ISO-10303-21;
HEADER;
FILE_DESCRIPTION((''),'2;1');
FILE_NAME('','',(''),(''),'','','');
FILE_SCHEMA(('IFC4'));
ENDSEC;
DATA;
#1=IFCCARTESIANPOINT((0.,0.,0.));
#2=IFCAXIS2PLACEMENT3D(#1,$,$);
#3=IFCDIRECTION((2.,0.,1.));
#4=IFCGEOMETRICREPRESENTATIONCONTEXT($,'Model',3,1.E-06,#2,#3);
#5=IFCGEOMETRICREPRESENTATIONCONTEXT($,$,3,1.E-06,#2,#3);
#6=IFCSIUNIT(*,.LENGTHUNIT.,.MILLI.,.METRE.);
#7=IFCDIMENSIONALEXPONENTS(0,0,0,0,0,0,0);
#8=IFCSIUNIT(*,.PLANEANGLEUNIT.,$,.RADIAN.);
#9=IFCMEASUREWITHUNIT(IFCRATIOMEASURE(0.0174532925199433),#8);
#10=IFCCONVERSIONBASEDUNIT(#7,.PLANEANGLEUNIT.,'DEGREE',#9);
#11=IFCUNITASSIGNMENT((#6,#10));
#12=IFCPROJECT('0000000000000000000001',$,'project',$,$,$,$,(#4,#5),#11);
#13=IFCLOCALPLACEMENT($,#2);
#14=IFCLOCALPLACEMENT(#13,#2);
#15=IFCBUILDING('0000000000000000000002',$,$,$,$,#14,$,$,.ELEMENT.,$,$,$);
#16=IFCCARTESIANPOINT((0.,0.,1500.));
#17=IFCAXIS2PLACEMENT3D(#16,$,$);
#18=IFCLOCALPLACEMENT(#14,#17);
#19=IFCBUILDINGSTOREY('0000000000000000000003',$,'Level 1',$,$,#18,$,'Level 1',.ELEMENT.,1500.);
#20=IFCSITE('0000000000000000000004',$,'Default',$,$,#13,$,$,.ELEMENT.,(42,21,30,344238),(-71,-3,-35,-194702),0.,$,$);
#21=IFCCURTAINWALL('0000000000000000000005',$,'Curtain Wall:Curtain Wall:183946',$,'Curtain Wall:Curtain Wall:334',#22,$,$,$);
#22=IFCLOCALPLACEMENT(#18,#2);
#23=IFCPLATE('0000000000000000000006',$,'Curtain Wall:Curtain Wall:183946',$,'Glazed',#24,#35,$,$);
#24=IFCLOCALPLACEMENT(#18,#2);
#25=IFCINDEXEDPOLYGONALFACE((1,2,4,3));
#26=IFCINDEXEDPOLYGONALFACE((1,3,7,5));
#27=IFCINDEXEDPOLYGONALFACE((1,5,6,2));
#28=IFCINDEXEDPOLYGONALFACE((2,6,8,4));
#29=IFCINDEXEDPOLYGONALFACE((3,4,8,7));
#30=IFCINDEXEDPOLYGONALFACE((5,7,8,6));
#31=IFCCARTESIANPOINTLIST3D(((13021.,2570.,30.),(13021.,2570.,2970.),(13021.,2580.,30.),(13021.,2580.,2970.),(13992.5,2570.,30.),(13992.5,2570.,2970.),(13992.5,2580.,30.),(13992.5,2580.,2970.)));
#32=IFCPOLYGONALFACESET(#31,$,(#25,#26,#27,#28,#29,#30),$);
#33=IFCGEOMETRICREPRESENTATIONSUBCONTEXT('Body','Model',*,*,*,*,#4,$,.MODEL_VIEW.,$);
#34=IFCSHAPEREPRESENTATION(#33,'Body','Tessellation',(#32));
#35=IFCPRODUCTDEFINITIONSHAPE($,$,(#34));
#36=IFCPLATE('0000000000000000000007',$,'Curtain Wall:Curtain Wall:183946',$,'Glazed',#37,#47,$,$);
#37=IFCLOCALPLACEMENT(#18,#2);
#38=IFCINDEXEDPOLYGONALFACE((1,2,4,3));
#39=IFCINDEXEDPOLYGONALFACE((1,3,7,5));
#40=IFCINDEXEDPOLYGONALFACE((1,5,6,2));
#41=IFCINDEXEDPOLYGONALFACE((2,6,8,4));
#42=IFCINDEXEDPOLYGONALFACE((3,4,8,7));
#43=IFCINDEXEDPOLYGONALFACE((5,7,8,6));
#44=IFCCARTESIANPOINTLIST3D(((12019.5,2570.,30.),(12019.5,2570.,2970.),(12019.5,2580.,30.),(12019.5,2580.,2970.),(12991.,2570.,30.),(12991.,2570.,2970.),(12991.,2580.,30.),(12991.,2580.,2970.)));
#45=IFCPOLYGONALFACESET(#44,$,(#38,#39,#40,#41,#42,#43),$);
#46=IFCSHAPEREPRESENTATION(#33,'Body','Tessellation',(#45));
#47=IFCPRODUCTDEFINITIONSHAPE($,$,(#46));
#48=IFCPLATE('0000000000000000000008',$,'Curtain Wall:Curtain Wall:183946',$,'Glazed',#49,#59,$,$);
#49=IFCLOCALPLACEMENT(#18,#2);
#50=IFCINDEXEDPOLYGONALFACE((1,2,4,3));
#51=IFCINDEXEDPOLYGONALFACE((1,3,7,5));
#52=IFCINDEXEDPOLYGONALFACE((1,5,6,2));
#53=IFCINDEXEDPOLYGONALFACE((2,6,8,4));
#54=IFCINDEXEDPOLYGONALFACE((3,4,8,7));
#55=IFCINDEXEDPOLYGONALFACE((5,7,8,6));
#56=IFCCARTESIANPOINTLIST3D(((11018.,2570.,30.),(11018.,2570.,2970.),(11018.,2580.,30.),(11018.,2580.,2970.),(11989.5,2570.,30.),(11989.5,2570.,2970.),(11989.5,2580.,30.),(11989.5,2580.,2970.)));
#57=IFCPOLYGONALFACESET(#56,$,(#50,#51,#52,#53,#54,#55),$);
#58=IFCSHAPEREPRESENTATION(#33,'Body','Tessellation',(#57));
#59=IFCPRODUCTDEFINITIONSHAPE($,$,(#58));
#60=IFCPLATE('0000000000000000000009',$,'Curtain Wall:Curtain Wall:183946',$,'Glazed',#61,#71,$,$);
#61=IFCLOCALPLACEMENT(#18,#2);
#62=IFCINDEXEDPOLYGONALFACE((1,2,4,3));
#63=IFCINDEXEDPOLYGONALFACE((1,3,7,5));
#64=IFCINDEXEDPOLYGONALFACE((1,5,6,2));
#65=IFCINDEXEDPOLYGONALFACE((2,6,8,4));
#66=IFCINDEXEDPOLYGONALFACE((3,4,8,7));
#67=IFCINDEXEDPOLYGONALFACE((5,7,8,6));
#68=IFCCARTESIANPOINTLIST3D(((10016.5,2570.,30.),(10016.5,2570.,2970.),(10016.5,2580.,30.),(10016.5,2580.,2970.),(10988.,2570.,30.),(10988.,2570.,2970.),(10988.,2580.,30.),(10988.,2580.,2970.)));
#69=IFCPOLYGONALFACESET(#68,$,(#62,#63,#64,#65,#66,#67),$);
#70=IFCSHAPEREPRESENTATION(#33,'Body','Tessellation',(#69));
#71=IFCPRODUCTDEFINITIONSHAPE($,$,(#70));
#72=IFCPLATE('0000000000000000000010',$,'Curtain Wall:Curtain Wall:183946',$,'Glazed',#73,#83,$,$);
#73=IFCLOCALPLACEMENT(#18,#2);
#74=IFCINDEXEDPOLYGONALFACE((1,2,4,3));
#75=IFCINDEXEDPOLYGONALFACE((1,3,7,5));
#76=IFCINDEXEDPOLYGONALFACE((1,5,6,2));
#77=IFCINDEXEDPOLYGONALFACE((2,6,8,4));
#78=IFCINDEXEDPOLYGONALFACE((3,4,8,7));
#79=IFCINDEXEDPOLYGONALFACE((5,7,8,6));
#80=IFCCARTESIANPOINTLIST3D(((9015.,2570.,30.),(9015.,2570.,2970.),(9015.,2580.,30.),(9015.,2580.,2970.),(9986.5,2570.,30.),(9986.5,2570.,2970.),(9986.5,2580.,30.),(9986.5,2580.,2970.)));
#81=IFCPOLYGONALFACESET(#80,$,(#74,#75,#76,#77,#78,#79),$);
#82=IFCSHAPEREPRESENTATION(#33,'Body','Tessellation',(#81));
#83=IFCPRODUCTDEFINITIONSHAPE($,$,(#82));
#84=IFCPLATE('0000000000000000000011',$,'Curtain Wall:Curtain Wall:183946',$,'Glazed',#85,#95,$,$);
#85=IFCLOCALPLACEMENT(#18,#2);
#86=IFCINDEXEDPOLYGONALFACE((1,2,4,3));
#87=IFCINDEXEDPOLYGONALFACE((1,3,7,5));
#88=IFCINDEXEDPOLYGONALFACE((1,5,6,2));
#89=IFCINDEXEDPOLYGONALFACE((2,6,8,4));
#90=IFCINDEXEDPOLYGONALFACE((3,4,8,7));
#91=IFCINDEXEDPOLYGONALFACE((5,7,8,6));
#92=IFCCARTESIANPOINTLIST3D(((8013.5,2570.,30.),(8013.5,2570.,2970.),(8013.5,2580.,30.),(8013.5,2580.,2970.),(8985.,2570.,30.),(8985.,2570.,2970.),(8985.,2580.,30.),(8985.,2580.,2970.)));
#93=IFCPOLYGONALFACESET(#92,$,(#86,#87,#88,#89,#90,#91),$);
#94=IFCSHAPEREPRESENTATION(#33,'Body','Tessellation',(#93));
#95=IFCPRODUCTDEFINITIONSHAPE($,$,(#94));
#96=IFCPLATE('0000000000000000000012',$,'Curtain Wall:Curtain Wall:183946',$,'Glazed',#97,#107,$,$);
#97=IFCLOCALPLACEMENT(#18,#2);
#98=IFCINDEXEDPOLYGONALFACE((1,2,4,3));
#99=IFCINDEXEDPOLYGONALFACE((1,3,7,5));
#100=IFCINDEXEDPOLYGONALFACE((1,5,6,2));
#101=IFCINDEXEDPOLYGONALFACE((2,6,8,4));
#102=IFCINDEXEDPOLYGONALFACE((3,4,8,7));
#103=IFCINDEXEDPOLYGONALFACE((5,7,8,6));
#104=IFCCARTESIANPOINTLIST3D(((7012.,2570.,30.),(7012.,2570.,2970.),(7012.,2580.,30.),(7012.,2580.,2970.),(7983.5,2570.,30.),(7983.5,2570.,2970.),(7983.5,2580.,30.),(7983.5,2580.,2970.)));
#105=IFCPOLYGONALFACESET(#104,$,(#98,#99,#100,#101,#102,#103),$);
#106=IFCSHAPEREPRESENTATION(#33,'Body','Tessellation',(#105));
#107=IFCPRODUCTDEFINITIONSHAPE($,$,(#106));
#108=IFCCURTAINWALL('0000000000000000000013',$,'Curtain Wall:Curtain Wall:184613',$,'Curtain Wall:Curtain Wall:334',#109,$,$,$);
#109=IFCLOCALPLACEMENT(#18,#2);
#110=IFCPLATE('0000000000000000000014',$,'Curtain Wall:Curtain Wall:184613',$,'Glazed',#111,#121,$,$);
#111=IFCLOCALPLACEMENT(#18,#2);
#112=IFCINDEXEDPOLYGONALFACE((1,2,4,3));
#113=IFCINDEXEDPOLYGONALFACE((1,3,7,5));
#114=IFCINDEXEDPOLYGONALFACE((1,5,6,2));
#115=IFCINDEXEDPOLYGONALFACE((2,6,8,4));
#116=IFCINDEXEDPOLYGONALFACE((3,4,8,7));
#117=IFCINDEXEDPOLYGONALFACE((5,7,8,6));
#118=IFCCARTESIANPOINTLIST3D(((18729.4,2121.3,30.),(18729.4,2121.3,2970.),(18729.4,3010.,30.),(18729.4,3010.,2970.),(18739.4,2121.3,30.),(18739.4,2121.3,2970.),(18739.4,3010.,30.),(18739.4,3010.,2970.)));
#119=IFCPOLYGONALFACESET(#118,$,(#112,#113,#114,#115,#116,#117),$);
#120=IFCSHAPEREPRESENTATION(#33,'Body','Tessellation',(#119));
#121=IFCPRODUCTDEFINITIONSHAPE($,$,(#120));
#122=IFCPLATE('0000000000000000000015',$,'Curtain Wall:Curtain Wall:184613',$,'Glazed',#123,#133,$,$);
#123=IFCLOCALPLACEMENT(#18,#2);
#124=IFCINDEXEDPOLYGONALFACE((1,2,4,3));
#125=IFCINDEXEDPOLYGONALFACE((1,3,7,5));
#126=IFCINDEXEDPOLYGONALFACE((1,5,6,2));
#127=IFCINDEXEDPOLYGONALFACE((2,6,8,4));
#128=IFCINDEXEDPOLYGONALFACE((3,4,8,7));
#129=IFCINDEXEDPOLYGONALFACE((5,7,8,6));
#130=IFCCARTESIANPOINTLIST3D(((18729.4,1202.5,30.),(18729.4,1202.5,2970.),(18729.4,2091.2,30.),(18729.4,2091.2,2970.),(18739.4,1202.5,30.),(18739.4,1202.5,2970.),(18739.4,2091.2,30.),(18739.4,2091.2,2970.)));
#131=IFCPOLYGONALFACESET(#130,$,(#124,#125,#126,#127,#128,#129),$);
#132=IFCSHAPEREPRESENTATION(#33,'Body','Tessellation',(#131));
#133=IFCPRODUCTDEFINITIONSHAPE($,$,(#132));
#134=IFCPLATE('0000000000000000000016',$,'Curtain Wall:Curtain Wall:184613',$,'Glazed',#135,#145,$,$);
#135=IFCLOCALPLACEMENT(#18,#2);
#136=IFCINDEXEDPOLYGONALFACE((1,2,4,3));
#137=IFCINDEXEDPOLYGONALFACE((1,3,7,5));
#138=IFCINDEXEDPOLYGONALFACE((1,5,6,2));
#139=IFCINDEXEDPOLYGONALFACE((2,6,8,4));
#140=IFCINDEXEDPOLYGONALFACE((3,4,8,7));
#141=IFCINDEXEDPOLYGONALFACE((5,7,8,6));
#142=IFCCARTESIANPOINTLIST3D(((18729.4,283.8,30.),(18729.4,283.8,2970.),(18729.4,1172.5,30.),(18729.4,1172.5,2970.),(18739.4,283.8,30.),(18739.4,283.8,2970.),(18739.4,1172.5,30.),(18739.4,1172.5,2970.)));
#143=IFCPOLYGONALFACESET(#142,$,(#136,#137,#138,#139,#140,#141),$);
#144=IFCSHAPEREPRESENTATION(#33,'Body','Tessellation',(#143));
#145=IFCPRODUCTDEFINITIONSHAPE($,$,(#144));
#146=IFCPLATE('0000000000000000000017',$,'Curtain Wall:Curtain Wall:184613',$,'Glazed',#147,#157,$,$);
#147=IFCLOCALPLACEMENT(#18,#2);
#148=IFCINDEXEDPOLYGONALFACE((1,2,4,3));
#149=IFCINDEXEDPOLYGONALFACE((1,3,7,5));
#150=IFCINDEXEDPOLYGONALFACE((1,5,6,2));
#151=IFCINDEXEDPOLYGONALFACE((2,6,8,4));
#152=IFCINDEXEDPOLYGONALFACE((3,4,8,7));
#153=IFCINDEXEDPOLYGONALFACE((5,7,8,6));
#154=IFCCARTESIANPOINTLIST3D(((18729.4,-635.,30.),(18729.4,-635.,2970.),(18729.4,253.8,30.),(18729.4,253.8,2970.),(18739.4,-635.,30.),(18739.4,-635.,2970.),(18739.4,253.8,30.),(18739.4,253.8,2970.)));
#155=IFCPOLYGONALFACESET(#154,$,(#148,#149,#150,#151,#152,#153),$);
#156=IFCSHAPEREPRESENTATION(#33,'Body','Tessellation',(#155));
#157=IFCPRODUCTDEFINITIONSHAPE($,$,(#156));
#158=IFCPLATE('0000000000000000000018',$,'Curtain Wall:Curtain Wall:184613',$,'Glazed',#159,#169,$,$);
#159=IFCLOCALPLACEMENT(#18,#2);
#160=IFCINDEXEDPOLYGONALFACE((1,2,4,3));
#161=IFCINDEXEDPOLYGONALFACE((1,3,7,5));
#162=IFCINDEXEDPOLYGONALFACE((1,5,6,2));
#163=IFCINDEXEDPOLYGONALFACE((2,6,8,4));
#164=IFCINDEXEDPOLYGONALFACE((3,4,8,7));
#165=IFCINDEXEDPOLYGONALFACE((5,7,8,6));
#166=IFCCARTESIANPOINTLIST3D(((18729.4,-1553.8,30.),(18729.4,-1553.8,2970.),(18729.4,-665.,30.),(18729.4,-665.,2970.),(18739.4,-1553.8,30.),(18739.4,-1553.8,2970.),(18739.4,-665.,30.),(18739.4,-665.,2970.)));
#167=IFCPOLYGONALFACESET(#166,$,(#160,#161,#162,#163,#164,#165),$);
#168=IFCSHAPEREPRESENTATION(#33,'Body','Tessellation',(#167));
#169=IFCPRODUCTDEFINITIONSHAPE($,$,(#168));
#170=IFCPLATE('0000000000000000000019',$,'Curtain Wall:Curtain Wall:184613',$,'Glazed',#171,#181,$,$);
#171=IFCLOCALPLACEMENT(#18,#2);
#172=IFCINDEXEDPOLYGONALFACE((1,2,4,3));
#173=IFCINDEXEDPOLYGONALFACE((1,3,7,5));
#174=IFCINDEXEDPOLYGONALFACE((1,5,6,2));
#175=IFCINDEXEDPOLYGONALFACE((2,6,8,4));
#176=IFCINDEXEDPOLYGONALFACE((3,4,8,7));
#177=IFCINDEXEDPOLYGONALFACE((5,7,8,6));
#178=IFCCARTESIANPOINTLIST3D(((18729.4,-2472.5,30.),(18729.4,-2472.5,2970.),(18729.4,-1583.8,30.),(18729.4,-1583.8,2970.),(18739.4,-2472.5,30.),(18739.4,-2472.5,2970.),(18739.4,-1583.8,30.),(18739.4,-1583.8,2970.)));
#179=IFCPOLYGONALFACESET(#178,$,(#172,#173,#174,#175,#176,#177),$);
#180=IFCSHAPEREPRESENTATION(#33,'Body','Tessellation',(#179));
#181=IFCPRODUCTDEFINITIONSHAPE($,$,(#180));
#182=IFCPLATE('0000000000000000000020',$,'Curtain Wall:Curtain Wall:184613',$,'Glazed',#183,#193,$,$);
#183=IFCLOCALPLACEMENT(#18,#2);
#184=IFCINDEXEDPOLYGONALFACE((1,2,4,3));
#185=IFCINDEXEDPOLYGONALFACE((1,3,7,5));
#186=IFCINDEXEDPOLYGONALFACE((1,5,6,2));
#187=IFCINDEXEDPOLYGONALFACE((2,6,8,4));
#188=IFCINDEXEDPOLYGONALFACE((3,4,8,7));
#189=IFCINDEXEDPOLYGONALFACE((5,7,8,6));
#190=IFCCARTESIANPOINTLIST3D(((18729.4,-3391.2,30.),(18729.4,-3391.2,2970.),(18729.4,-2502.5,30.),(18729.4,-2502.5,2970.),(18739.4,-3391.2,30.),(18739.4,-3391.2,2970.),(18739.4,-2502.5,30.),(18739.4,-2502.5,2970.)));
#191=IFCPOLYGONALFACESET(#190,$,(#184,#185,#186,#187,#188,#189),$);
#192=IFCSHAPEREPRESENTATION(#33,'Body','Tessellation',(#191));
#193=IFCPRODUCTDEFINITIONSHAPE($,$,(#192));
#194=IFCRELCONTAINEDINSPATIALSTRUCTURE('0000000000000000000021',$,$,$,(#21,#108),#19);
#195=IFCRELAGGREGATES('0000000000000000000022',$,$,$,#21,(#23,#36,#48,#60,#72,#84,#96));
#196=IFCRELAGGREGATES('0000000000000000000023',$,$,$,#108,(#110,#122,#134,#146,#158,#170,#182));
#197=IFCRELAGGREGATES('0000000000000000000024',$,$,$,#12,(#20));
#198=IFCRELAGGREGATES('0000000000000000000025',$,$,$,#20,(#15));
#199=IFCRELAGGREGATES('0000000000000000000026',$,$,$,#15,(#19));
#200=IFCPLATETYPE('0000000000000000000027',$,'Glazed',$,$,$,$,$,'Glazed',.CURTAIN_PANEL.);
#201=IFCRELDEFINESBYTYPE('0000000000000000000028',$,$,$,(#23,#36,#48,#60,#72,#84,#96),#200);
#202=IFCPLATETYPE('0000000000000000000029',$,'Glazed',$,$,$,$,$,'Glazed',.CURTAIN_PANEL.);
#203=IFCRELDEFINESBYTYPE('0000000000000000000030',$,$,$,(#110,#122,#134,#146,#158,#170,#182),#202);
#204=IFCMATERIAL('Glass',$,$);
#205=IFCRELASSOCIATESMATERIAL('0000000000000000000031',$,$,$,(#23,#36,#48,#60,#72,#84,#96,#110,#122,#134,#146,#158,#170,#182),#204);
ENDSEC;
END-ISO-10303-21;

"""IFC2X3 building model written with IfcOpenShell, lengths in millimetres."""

from ifc_helpers import new_model, entity, si_unit, converted_unit, direction, frame, origin, origin_2d_with_axis, place, context, subcontext, project, spatial, rectangle, extrude, source, transform, mapped, material, type_object, type_shapes, element, aggregate, save


model = new_model("IFC2X3")

# Units and contexts
model_context = context("Model", 3, precision=1e-06, world=origin(), true_north=direction((2.0, 0.0, 1.0)))
context_of_model = context(None, 3, precision=1e-06, world=origin(), true_north=direction((2.0, 0.0, 1.0)))
body_context = subcontext(model_context, "Body", "Model", "MODEL_VIEW")
ifc_project = project(units=[si_unit("LENGTHUNIT", "METRE", prefix="MILLI"), converted_unit("PLANEANGLEUNIT", "DEGREE", entity("IfcRatioMeasure", 0.0174532925199433), si_unit("PLANEANGLEUNIT", "RADIAN"), dimensions=[0, 0, 0, 0, 0, 0, 0])], contexts=[model_context, context_of_model])

# Site, building, storey
site_placement = place(None, origin())
site = spatial("IfcSite", under=ifc_project, at=site_placement, Name="Default", CompositionType="ELEMENT", RefLatitude=(42, 21, 30, 344238), RefLongitude=(-71, -3, -35, -194702), RefElevation=0.0)
building_placement = place(site_placement, origin())
building = spatial("IfcBuilding", under=site, at=building_placement, CompositionType="ELEMENT")
storey_placement = place(building_placement, frame((0.0, 0.0, 1500.0)))
storey = spatial("IfcBuildingStorey", under=building, at=storey_placement, Name="Level 1", LongName="Level 1", CompositionType="ELEMENT", Elevation=1500.0)

# Curtain walls, plates
curtain_wall_1_placement = place(storey_placement, origin())
curtain_wall_1 = element("IfcCurtainWall", 1, at=curtain_wall_1_placement, inside=storey, Name="Curtain Wall:Curtain Wall:183946", ObjectType="Curtain Wall:Curtain Wall:334")
ifc_material_1 = material(Name="Glass")
plate_type_1 = type_object("IfcPlateType", Name="Glazed", ElementType="Glazed", PredefinedType="CURTAIN_PANEL")
shared_shape_1 = source(origin(), body_context, "Body", "SweptSolid", [
    extrude(rectangle(XDim=10.0, YDim=971.5, at=origin_2d_with_axis()), frame((0.0, 0.0, 0.0), z_axis=(0.0, 0.0, 1.0), x_axis=(0.0, 1.0, 0.0)), (0.0, 0.0, 1.0), 2940.0),
])
type_shapes(plate_type_1, [shared_shape_1])
plate_1_placement = place(storey_placement, frame((13506.8, 2575.0, 30.0), z_axis=(0.0, 0.0, 1.0), x_axis=(-1.0, 0.0, 0.0)))
plate_1 = element("IfcPlate", 2, at=plate_1_placement, type_object=plate_type_1, material=ifc_material_1, Name="Curtain Wall:Curtain Wall:183946", ObjectType="Glazed", context=body_context, shape_type="MappedRepresentation", body=[
    mapped(shared_shape_1, transform((0.0, 0.0, 0.0), scale=1.0)),
])
plate_2_placement = place(storey_placement, frame((12505.2, 2575.0, 30.0), z_axis=(0.0, 0.0, 1.0), x_axis=(-1.0, 0.0, 0.0)))
plate_2 = element("IfcPlate", 3, at=plate_2_placement, type_object=plate_type_1, material=ifc_material_1, Name="Curtain Wall:Curtain Wall:183946", ObjectType="Glazed", context=body_context, shape_type="MappedRepresentation", body=[
    mapped(shared_shape_1, transform((0.0, 0.0, 0.0), scale=1.0)),
])
plate_3_placement = place(storey_placement, frame((11503.8, 2575.0, 30.0), z_axis=(0.0, 0.0, 1.0), x_axis=(-1.0, 0.0, 0.0)))
plate_3 = element("IfcPlate", 4, at=plate_3_placement, type_object=plate_type_1, material=ifc_material_1, Name="Curtain Wall:Curtain Wall:183946", ObjectType="Glazed", context=body_context, shape_type="MappedRepresentation", body=[
    mapped(shared_shape_1, transform((0.0, 0.0, 0.0), scale=1.0)),
])
plate_4_placement = place(storey_placement, frame((10502.2, 2575.0, 30.0), z_axis=(0.0, 0.0, 1.0), x_axis=(-1.0, 0.0, 0.0)))
plate_4 = element("IfcPlate", 5, at=plate_4_placement, type_object=plate_type_1, material=ifc_material_1, Name="Curtain Wall:Curtain Wall:183946", ObjectType="Glazed", context=body_context, shape_type="MappedRepresentation", body=[
    mapped(shared_shape_1, transform((0.0, 0.0, 0.0), scale=1.0)),
])
plate_5_placement = place(storey_placement, frame((9500.8, 2575.0, 30.0), z_axis=(0.0, 0.0, 1.0), x_axis=(-1.0, 0.0, 0.0)))
plate_5 = element("IfcPlate", 6, at=plate_5_placement, type_object=plate_type_1, material=ifc_material_1, Name="Curtain Wall:Curtain Wall:183946", ObjectType="Glazed", context=body_context, shape_type="MappedRepresentation", body=[
    mapped(shared_shape_1, transform((0.0, 0.0, 0.0), scale=1.0)),
])
plate_6_placement = place(storey_placement, frame((8499.2, 2575.0, 30.0), z_axis=(0.0, 0.0, 1.0), x_axis=(-1.0, 0.0, 0.0)))
plate_6 = element("IfcPlate", 7, at=plate_6_placement, type_object=plate_type_1, material=ifc_material_1, Name="Curtain Wall:Curtain Wall:183946", ObjectType="Glazed", context=body_context, shape_type="MappedRepresentation", body=[
    mapped(shared_shape_1, transform((0.0, 0.0, 0.0), scale=1.0)),
])
plate_7_placement = place(storey_placement, frame((7497.8, 2575.0, 30.0), z_axis=(0.0, 0.0, 1.0), x_axis=(-1.0, 0.0, 0.0)))
plate_7 = element("IfcPlate", 8, at=plate_7_placement, type_object=plate_type_1, material=ifc_material_1, Name="Curtain Wall:Curtain Wall:183946", ObjectType="Glazed", context=body_context, shape_type="MappedRepresentation", body=[
    mapped(shared_shape_1, transform((0.0, 0.0, 0.0), scale=1.0)),
])
aggregate(curtain_wall_1, [plate_1, plate_2, plate_3, plate_4, plate_5, plate_6, plate_7])
curtain_wall_2_placement = place(storey_placement, origin())
curtain_wall_2 = element("IfcCurtainWall", 9, at=curtain_wall_2_placement, inside=storey, Name="Curtain Wall:Curtain Wall:184613", ObjectType="Curtain Wall:Curtain Wall:334")
plate_type_2 = type_object("IfcPlateType", Name="Glazed", ElementType="Glazed", PredefinedType="CURTAIN_PANEL")
shared_shape_2 = source(origin(), body_context, "Body", "SweptSolid", [
    extrude(rectangle(XDim=10.0, YDim=888.8, at=origin_2d_with_axis()), frame((0.0, 0.0, 0.0), z_axis=(0.0, 0.0, 1.0), x_axis=(0.0, 1.0, 0.0)), (0.0, 0.0, 1.0), 2940.0),
])
type_shapes(plate_type_2, [shared_shape_2])
plate_8_placement = place(storey_placement, frame((18734.4, 2565.6, 30.0), z_axis=(0.0, 0.0, 1.0), x_axis=(0.0, -1.0, 0.0)))
plate_8 = element("IfcPlate", 10, at=plate_8_placement, type_object=plate_type_2, material=ifc_material_1, Name="Curtain Wall:Curtain Wall:184613", ObjectType="Glazed", context=body_context, shape_type="MappedRepresentation", body=[
    mapped(shared_shape_2, transform((0.0, 0.0, 0.0), scale=1.0)),
])
plate_9_placement = place(storey_placement, frame((18734.4, 1646.9, 30.0), z_axis=(0.0, 0.0, 1.0), x_axis=(0.0, -1.0, 0.0)))
plate_9 = element("IfcPlate", 11, at=plate_9_placement, type_object=plate_type_2, material=ifc_material_1, Name="Curtain Wall:Curtain Wall:184613", ObjectType="Glazed", context=body_context, shape_type="MappedRepresentation", body=[
    mapped(shared_shape_2, transform((0.0, 0.0, 0.0), scale=1.0)),
])
plate_10_placement = place(storey_placement, frame((18734.4, 728.1, 30.0), z_axis=(0.0, 0.0, 1.0), x_axis=(0.0, -1.0, 0.0)))
plate_10 = element("IfcPlate", 12, at=plate_10_placement, type_object=plate_type_2, material=ifc_material_1, Name="Curtain Wall:Curtain Wall:184613", ObjectType="Glazed", context=body_context, shape_type="MappedRepresentation", body=[
    mapped(shared_shape_2, transform((0.0, 0.0, 0.0), scale=1.0)),
])
plate_11_placement = place(storey_placement, frame((18734.4, -190.6, 30.0), z_axis=(0.0, 0.0, 1.0), x_axis=(0.0, -1.0, 0.0)))
plate_11 = element("IfcPlate", 13, at=plate_11_placement, type_object=plate_type_2, material=ifc_material_1, Name="Curtain Wall:Curtain Wall:184613", ObjectType="Glazed", context=body_context, shape_type="MappedRepresentation", body=[
    mapped(shared_shape_2, transform((0.0, 0.0, 0.0), scale=1.0)),
])
plate_12_placement = place(storey_placement, frame((18734.4, -1109.4, 30.0), z_axis=(0.0, 0.0, 1.0), x_axis=(0.0, -1.0, 0.0)))
plate_12 = element("IfcPlate", 14, at=plate_12_placement, type_object=plate_type_2, material=ifc_material_1, Name="Curtain Wall:Curtain Wall:184613", ObjectType="Glazed", context=body_context, shape_type="MappedRepresentation", body=[
    mapped(shared_shape_2, transform((0.0, 0.0, 0.0), scale=1.0)),
])
plate_13_placement = place(storey_placement, frame((18734.4, -2028.1, 30.0), z_axis=(0.0, 0.0, 1.0), x_axis=(0.0, -1.0, 0.0)))
plate_13 = element("IfcPlate", 15, at=plate_13_placement, type_object=plate_type_2, material=ifc_material_1, Name="Curtain Wall:Curtain Wall:184613", ObjectType="Glazed", context=body_context, shape_type="MappedRepresentation", body=[
    mapped(shared_shape_2, transform((0.0, 0.0, 0.0), scale=1.0)),
])
plate_14_placement = place(storey_placement, frame((18734.4, -2946.9, 30.0), z_axis=(0.0, 0.0, 1.0), x_axis=(0.0, -1.0, 0.0)))
plate_14 = element("IfcPlate", 16, at=plate_14_placement, type_object=plate_type_2, material=ifc_material_1, Name="Curtain Wall:Curtain Wall:184613", ObjectType="Glazed", context=body_context, shape_type="MappedRepresentation", body=[
    mapped(shared_shape_2, transform((0.0, 0.0, 0.0), scale=1.0)),
])
aggregate(curtain_wall_2, [plate_8, plate_9, plate_10, plate_11, plate_12, plate_13, plate_14])

save(model, "model.ifc")
